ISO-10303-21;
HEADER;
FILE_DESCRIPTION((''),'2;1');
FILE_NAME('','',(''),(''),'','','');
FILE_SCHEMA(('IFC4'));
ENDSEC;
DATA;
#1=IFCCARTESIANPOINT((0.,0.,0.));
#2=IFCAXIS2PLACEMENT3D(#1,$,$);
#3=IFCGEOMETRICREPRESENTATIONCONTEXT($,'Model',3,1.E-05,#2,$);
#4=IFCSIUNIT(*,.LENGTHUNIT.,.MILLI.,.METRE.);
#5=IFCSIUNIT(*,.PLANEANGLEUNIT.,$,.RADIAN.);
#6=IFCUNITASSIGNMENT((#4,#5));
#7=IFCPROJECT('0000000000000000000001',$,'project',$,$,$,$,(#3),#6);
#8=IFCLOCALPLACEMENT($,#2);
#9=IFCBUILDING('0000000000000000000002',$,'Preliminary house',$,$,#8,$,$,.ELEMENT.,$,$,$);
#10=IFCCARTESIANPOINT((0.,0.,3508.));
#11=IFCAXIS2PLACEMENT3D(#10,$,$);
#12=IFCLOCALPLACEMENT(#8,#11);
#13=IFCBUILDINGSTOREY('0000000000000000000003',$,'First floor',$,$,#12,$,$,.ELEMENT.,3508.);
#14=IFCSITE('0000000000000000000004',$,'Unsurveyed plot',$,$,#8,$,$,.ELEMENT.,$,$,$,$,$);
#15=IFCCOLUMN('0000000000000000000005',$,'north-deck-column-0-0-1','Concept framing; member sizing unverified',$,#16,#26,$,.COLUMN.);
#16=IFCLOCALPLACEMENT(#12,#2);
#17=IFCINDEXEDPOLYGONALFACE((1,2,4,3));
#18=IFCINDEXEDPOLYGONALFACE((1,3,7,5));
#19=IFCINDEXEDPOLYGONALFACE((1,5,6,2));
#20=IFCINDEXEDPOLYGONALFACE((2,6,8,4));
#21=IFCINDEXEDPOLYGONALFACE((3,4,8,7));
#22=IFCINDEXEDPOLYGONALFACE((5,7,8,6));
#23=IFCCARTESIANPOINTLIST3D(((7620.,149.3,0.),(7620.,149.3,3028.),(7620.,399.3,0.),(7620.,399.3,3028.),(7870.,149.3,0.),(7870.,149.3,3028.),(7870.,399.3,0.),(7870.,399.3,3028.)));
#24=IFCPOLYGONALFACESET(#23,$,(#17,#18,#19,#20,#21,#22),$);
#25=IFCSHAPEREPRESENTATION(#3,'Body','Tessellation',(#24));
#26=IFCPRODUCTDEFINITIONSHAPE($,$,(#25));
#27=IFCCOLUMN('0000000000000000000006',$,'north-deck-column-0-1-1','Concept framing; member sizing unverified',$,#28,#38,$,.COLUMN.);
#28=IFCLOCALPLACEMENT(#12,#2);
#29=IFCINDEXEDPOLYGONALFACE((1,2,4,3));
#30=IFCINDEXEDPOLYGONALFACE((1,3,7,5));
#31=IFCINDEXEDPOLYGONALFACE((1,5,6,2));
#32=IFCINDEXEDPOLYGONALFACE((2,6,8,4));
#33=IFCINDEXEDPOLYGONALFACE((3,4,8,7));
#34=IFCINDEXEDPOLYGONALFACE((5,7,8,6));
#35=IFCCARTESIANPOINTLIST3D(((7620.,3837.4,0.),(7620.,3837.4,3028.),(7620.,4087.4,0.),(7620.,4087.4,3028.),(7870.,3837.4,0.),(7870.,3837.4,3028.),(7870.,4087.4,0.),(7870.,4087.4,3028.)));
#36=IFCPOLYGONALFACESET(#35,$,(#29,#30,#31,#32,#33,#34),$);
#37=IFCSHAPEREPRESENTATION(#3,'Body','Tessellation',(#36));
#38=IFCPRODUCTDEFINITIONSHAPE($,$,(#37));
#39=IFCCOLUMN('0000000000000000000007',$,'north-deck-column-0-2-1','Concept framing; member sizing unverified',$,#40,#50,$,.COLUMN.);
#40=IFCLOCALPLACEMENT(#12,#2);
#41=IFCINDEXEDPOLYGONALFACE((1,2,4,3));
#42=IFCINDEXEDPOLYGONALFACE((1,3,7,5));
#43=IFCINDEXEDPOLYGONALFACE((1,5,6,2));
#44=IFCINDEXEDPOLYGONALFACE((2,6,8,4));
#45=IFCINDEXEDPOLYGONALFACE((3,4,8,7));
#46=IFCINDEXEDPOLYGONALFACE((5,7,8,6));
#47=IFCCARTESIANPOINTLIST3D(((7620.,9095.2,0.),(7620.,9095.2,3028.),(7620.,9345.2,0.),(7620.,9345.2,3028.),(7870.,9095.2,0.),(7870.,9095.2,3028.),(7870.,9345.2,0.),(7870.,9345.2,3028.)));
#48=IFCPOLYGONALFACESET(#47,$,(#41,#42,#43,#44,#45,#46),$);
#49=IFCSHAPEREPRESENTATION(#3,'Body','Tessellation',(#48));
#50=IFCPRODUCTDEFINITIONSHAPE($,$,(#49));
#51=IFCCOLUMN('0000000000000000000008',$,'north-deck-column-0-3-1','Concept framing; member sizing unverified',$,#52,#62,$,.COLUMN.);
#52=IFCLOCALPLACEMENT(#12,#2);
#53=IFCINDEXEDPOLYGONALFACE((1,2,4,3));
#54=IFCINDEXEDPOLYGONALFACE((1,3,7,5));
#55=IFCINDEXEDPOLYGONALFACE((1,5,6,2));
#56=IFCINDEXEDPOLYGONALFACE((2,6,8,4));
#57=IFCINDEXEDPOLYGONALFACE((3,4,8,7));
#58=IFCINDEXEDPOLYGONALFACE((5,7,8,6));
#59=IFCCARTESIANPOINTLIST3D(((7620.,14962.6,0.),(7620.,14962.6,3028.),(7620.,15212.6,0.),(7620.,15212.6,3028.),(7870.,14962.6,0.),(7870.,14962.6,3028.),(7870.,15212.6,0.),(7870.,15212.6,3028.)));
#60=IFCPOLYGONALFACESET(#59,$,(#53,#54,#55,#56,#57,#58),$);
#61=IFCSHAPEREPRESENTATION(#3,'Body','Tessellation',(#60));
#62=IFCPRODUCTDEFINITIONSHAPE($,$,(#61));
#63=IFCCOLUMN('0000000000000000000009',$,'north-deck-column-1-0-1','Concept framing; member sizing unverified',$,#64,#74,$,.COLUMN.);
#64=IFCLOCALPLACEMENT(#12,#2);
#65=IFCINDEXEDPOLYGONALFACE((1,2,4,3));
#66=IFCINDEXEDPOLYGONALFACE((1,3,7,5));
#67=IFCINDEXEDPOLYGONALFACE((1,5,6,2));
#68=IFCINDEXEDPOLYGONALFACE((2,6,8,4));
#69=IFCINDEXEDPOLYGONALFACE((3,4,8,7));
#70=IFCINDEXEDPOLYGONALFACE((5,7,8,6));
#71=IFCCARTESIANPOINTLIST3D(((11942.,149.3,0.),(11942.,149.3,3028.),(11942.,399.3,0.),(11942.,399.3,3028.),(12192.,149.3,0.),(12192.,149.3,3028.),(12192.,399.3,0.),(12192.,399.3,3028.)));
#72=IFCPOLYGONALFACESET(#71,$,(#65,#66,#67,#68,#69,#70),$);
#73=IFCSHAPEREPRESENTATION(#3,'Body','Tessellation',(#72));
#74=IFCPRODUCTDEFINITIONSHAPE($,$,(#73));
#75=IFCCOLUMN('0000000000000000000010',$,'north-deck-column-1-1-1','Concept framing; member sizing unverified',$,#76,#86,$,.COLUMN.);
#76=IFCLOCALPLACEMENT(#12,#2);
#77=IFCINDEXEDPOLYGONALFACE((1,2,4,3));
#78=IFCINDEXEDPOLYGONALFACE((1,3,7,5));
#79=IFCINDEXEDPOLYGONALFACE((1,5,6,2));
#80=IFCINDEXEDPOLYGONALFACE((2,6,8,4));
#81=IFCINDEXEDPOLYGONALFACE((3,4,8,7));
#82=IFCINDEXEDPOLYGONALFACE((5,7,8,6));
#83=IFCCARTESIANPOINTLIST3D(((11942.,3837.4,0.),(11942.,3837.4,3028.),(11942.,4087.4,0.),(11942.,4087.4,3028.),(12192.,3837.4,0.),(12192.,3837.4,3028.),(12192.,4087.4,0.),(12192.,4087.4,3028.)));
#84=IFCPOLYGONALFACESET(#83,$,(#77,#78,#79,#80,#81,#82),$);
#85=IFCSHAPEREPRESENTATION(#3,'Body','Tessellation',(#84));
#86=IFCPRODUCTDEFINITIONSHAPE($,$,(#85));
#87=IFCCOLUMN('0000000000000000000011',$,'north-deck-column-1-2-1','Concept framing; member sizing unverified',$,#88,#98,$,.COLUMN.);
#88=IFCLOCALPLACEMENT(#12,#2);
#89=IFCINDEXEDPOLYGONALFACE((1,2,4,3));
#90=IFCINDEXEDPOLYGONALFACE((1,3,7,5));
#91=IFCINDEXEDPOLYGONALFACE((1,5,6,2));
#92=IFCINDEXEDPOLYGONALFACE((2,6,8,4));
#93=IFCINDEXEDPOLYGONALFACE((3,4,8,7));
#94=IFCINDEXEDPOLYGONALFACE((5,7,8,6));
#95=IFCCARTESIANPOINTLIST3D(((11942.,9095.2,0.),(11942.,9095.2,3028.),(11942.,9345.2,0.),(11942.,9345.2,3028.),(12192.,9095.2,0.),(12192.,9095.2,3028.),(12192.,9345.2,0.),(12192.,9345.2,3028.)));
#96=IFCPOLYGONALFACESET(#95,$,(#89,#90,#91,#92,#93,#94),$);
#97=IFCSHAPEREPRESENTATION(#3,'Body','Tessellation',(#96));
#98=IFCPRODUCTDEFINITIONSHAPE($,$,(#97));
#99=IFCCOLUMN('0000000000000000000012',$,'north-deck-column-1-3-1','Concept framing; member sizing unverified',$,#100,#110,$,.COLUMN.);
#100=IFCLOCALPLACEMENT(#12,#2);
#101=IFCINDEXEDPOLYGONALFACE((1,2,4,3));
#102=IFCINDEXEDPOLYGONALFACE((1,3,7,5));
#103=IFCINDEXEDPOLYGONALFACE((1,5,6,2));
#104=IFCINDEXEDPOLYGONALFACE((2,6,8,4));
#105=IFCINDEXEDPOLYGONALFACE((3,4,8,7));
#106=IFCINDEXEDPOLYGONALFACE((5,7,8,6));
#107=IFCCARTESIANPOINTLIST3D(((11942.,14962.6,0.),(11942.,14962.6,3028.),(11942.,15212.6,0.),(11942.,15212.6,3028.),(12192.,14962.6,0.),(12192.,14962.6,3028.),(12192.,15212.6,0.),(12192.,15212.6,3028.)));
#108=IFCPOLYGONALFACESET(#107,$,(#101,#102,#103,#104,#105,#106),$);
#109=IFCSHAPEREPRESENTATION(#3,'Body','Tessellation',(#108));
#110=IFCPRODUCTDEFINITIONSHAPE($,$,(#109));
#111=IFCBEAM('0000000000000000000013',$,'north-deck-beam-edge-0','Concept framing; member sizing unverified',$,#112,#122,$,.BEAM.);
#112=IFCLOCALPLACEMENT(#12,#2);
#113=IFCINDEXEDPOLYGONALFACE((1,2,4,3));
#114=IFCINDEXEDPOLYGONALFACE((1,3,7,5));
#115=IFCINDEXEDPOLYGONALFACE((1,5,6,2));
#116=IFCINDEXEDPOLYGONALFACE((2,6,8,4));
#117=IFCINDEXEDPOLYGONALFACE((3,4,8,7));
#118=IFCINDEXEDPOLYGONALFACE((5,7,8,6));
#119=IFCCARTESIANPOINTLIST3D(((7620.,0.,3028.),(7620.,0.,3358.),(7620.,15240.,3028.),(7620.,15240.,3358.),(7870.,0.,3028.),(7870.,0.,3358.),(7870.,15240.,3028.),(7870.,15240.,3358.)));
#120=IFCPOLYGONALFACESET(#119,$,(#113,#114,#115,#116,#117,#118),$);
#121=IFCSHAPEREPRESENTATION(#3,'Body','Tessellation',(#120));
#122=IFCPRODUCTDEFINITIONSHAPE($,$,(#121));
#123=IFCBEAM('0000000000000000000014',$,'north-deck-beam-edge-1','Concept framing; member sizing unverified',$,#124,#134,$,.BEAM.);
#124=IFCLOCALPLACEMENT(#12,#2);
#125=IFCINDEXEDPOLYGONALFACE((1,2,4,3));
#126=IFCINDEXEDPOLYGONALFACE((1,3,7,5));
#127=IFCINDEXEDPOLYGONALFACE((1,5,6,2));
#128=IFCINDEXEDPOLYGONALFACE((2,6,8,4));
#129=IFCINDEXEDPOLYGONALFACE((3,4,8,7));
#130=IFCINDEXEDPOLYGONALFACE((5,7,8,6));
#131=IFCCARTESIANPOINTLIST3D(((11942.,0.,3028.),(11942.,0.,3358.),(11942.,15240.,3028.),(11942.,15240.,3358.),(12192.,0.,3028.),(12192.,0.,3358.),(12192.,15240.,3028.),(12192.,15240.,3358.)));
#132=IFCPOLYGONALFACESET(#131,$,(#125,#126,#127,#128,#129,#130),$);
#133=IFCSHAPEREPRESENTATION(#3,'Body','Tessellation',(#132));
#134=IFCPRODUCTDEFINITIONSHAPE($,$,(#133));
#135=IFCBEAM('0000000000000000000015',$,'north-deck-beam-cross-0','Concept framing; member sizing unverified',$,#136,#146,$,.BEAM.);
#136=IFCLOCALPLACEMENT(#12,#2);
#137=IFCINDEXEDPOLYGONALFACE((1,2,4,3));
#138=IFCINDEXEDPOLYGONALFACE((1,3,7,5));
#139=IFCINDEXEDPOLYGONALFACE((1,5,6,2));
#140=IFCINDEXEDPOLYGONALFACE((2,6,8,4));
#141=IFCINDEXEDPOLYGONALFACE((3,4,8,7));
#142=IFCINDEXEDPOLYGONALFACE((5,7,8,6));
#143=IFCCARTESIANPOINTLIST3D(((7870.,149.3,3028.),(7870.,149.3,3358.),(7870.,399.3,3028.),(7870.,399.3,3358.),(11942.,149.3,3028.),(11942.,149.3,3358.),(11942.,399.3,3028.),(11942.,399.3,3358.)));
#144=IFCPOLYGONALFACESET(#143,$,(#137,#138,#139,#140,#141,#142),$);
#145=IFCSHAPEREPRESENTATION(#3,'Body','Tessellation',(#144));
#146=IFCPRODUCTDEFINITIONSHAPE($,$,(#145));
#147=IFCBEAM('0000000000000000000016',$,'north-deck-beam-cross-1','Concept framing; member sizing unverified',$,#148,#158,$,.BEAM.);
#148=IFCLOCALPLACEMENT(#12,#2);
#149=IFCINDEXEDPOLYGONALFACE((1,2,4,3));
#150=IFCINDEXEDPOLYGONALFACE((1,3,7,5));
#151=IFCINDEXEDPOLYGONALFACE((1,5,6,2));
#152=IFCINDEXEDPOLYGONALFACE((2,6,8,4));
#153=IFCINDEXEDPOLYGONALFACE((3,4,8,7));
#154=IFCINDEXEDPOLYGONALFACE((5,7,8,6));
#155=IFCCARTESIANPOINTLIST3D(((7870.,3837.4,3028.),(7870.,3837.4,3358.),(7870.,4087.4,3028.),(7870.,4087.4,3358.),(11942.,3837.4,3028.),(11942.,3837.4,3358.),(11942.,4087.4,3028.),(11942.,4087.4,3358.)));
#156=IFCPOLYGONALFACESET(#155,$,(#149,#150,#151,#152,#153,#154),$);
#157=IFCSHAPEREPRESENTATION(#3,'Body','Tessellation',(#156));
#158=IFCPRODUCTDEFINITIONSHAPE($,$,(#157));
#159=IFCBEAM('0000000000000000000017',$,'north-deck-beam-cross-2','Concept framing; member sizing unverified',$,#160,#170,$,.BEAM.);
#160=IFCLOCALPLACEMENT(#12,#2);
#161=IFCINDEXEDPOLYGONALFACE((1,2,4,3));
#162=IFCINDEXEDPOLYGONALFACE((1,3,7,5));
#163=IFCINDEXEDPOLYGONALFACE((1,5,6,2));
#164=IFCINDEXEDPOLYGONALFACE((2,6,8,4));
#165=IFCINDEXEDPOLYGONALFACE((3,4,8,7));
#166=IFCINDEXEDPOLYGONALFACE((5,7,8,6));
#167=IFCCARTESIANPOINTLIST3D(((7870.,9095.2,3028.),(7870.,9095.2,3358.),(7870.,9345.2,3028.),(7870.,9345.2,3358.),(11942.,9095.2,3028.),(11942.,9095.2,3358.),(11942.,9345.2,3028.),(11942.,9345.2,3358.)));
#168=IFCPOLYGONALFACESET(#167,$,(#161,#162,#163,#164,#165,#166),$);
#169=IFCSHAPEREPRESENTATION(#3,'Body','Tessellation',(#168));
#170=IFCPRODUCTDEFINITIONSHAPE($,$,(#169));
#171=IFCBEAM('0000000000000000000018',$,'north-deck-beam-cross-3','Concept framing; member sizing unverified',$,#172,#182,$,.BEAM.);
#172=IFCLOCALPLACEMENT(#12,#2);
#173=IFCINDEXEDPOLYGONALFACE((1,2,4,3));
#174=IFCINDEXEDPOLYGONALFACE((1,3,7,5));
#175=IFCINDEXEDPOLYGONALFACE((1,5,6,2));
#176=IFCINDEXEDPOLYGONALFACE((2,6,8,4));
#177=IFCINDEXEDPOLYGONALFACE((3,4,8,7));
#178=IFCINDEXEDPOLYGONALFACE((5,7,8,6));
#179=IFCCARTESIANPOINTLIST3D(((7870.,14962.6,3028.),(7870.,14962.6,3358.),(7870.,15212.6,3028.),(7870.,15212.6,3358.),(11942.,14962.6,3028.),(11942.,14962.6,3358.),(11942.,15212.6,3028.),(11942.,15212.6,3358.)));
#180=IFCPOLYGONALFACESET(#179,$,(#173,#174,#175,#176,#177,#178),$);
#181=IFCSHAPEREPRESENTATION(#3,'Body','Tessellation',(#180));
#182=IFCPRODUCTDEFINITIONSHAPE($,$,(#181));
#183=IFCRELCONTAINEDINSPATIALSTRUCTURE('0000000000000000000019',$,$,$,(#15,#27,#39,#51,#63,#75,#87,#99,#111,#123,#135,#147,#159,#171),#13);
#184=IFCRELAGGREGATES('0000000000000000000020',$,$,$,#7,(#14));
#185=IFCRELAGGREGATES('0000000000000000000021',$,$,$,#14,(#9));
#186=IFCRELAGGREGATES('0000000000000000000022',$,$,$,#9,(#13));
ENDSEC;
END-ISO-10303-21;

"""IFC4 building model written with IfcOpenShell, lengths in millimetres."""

from ifc_helpers import new_model, si_unit, frame, origin, place, context, project, spatial, polyline, outline, extrude, element, save


model = new_model("IFC4")

# Units and contexts
model_context = context("Model", 3, precision=1e-05, world=origin())
ifc_project = project(units=[si_unit("LENGTHUNIT", "METRE", prefix="MILLI"), si_unit("PLANEANGLEUNIT", "RADIAN")], contexts=[model_context])

# Site, building, storey
placement_1 = place(None, origin())
site = spatial("IfcSite", under=ifc_project, at=placement_1, Name="Unsurveyed plot", CompositionType="ELEMENT")
building = spatial("IfcBuilding", under=site, at=placement_1, Name="Preliminary house", CompositionType="ELEMENT")
placement_2 = place(placement_1, frame((0.0, 0.0, 3508.0)))
storey = spatial("IfcBuildingStorey", under=building, at=placement_2, Name="First floor", CompositionType="ELEMENT", Elevation=3508.0)

# Columns
element("IfcColumn", 1, at=placement_2, inside=storey, Name="north-deck-column-0-0-1", Description="Concept framing; member sizing unverified", PredefinedType="COLUMN", context=model_context, shape_type="SweptSolid", body=[
    extrude(outline(polyline([(7870.0, 149.3), (7870.0, 399.3), (7620.0, 399.3), (7620.0, 149.3), (7870.0, 149.3)])), origin(), (0.0, 0.0, 1.0), 3028.0),
])
element("IfcColumn", 2, at=placement_2, inside=storey, Name="north-deck-column-0-1-1", Description="Concept framing; member sizing unverified", PredefinedType="COLUMN", context=model_context, shape_type="SweptSolid", body=[
    extrude(outline(polyline([(7870.0, 3837.4), (7870.0, 4087.4), (7620.0, 4087.4), (7620.0, 3837.4), (7870.0, 3837.4)])), origin(), (0.0, 0.0, 1.0), 3028.0),
])
element("IfcColumn", 3, at=placement_2, inside=storey, Name="north-deck-column-0-2-1", Description="Concept framing; member sizing unverified", PredefinedType="COLUMN", context=model_context, shape_type="SweptSolid", body=[
    extrude(outline(polyline([(7870.0, 9095.2), (7870.0, 9345.2), (7620.0, 9345.2), (7620.0, 9095.2), (7870.0, 9095.2)])), origin(), (0.0, 0.0, 1.0), 3028.0),
])
element("IfcColumn", 4, at=placement_2, inside=storey, Name="north-deck-column-0-3-1", Description="Concept framing; member sizing unverified", PredefinedType="COLUMN", context=model_context, shape_type="SweptSolid", body=[
    extrude(outline(polyline([(7870.0, 14962.6), (7870.0, 15212.6), (7620.0, 15212.6), (7620.0, 14962.6), (7870.0, 14962.6)])), origin(), (0.0, 0.0, 1.0), 3028.0),
])
element("IfcColumn", 5, at=placement_2, inside=storey, Name="north-deck-column-1-0-1", Description="Concept framing; member sizing unverified", PredefinedType="COLUMN", context=model_context, shape_type="SweptSolid", body=[
    extrude(outline(polyline([(12192.0, 149.3), (12192.0, 399.3), (11942.0, 399.3), (11942.0, 149.3), (12192.0, 149.3)])), origin(), (0.0, 0.0, 1.0), 3028.0),
])
element("IfcColumn", 6, at=placement_2, inside=storey, Name="north-deck-column-1-1-1", Description="Concept framing; member sizing unverified", PredefinedType="COLUMN", context=model_context, shape_type="SweptSolid", body=[
    extrude(outline(polyline([(12192.0, 3837.4), (12192.0, 4087.4), (11942.0, 4087.4), (11942.0, 3837.4), (12192.0, 3837.4)])), origin(), (0.0, 0.0, 1.0), 3028.0),
])
element("IfcColumn", 7, at=placement_2, inside=storey, Name="north-deck-column-1-2-1", Description="Concept framing; member sizing unverified", PredefinedType="COLUMN", context=model_context, shape_type="SweptSolid", body=[
    extrude(outline(polyline([(12192.0, 9095.2), (12192.0, 9345.2), (11942.0, 9345.2), (11942.0, 9095.2), (12192.0, 9095.2)])), origin(), (0.0, 0.0, 1.0), 3028.0),
])
element("IfcColumn", 8, at=placement_2, inside=storey, Name="north-deck-column-1-3-1", Description="Concept framing; member sizing unverified", PredefinedType="COLUMN", context=model_context, shape_type="SweptSolid", body=[
    extrude(outline(polyline([(12192.0, 14962.6), (12192.0, 15212.6), (11942.0, 15212.6), (11942.0, 14962.6), (12192.0, 14962.6)])), origin(), (0.0, 0.0, 1.0), 3028.0),
])

# Beams
element("IfcBeam", 9, at=placement_2, inside=storey, Name="north-deck-beam-edge-0", Description="Concept framing; member sizing unverified", PredefinedType="BEAM", context=model_context, shape_type="SweptSolid", body=[
    extrude(outline(polyline([(7870.0, 0.0), (7870.0, 15240.0), (7620.0, 15240.0), (7620.0, 0.0), (7870.0, 0.0)])), frame((0.0, 0.0, 3028.0)), (0.0, 0.0, 1.0), 330.0),
])
element("IfcBeam", 10, at=placement_2, inside=storey, Name="north-deck-beam-edge-1", Description="Concept framing; member sizing unverified", PredefinedType="BEAM", context=model_context, shape_type="SweptSolid", body=[
    extrude(outline(polyline([(12192.0, 0.0), (12192.0, 15240.0), (11942.0, 15240.0), (11942.0, 0.0), (12192.0, 0.0)])), frame((0.0, 0.0, 3028.0)), (0.0, 0.0, 1.0), 330.0),
])
element("IfcBeam", 11, at=placement_2, inside=storey, Name="north-deck-beam-cross-0", Description="Concept framing; member sizing unverified", PredefinedType="BEAM", context=model_context, shape_type="SweptSolid", body=[
    extrude(outline(polyline([(11942.0, 149.3), (11942.0, 399.3), (7870.0, 399.3), (7870.0, 149.3), (11942.0, 149.3)])), frame((0.0, 0.0, 3028.0)), (0.0, 0.0, 1.0), 330.0),
])
element("IfcBeam", 12, at=placement_2, inside=storey, Name="north-deck-beam-cross-1", Description="Concept framing; member sizing unverified", PredefinedType="BEAM", context=model_context, shape_type="SweptSolid", body=[
    extrude(outline(polyline([(11942.0, 3837.4), (11942.0, 4087.4), (7870.0, 4087.4), (7870.0, 3837.4), (11942.0, 3837.4)])), frame((0.0, 0.0, 3028.0)), (0.0, 0.0, 1.0), 330.0),
])
element("IfcBeam", 13, at=placement_2, inside=storey, Name="north-deck-beam-cross-2", Description="Concept framing; member sizing unverified", PredefinedType="BEAM", context=model_context, shape_type="SweptSolid", body=[
    extrude(outline(polyline([(11942.0, 9095.2), (11942.0, 9345.2), (7870.0, 9345.2), (7870.0, 9095.2), (11942.0, 9095.2)])), frame((0.0, 0.0, 3028.0)), (0.0, 0.0, 1.0), 330.0),
])
element("IfcBeam", 14, at=placement_2, inside=storey, Name="north-deck-beam-cross-3", Description="Concept framing; member sizing unverified", PredefinedType="BEAM", context=model_context, shape_type="SweptSolid", body=[
    extrude(outline(polyline([(11942.0, 14962.6), (11942.0, 15212.6), (7870.0, 15212.6), (7870.0, 14962.6), (11942.0, 14962.6)])), frame((0.0, 0.0, 3028.0)), (0.0, 0.0, 1.0), 330.0),
])

save(model, "model.ifc")
